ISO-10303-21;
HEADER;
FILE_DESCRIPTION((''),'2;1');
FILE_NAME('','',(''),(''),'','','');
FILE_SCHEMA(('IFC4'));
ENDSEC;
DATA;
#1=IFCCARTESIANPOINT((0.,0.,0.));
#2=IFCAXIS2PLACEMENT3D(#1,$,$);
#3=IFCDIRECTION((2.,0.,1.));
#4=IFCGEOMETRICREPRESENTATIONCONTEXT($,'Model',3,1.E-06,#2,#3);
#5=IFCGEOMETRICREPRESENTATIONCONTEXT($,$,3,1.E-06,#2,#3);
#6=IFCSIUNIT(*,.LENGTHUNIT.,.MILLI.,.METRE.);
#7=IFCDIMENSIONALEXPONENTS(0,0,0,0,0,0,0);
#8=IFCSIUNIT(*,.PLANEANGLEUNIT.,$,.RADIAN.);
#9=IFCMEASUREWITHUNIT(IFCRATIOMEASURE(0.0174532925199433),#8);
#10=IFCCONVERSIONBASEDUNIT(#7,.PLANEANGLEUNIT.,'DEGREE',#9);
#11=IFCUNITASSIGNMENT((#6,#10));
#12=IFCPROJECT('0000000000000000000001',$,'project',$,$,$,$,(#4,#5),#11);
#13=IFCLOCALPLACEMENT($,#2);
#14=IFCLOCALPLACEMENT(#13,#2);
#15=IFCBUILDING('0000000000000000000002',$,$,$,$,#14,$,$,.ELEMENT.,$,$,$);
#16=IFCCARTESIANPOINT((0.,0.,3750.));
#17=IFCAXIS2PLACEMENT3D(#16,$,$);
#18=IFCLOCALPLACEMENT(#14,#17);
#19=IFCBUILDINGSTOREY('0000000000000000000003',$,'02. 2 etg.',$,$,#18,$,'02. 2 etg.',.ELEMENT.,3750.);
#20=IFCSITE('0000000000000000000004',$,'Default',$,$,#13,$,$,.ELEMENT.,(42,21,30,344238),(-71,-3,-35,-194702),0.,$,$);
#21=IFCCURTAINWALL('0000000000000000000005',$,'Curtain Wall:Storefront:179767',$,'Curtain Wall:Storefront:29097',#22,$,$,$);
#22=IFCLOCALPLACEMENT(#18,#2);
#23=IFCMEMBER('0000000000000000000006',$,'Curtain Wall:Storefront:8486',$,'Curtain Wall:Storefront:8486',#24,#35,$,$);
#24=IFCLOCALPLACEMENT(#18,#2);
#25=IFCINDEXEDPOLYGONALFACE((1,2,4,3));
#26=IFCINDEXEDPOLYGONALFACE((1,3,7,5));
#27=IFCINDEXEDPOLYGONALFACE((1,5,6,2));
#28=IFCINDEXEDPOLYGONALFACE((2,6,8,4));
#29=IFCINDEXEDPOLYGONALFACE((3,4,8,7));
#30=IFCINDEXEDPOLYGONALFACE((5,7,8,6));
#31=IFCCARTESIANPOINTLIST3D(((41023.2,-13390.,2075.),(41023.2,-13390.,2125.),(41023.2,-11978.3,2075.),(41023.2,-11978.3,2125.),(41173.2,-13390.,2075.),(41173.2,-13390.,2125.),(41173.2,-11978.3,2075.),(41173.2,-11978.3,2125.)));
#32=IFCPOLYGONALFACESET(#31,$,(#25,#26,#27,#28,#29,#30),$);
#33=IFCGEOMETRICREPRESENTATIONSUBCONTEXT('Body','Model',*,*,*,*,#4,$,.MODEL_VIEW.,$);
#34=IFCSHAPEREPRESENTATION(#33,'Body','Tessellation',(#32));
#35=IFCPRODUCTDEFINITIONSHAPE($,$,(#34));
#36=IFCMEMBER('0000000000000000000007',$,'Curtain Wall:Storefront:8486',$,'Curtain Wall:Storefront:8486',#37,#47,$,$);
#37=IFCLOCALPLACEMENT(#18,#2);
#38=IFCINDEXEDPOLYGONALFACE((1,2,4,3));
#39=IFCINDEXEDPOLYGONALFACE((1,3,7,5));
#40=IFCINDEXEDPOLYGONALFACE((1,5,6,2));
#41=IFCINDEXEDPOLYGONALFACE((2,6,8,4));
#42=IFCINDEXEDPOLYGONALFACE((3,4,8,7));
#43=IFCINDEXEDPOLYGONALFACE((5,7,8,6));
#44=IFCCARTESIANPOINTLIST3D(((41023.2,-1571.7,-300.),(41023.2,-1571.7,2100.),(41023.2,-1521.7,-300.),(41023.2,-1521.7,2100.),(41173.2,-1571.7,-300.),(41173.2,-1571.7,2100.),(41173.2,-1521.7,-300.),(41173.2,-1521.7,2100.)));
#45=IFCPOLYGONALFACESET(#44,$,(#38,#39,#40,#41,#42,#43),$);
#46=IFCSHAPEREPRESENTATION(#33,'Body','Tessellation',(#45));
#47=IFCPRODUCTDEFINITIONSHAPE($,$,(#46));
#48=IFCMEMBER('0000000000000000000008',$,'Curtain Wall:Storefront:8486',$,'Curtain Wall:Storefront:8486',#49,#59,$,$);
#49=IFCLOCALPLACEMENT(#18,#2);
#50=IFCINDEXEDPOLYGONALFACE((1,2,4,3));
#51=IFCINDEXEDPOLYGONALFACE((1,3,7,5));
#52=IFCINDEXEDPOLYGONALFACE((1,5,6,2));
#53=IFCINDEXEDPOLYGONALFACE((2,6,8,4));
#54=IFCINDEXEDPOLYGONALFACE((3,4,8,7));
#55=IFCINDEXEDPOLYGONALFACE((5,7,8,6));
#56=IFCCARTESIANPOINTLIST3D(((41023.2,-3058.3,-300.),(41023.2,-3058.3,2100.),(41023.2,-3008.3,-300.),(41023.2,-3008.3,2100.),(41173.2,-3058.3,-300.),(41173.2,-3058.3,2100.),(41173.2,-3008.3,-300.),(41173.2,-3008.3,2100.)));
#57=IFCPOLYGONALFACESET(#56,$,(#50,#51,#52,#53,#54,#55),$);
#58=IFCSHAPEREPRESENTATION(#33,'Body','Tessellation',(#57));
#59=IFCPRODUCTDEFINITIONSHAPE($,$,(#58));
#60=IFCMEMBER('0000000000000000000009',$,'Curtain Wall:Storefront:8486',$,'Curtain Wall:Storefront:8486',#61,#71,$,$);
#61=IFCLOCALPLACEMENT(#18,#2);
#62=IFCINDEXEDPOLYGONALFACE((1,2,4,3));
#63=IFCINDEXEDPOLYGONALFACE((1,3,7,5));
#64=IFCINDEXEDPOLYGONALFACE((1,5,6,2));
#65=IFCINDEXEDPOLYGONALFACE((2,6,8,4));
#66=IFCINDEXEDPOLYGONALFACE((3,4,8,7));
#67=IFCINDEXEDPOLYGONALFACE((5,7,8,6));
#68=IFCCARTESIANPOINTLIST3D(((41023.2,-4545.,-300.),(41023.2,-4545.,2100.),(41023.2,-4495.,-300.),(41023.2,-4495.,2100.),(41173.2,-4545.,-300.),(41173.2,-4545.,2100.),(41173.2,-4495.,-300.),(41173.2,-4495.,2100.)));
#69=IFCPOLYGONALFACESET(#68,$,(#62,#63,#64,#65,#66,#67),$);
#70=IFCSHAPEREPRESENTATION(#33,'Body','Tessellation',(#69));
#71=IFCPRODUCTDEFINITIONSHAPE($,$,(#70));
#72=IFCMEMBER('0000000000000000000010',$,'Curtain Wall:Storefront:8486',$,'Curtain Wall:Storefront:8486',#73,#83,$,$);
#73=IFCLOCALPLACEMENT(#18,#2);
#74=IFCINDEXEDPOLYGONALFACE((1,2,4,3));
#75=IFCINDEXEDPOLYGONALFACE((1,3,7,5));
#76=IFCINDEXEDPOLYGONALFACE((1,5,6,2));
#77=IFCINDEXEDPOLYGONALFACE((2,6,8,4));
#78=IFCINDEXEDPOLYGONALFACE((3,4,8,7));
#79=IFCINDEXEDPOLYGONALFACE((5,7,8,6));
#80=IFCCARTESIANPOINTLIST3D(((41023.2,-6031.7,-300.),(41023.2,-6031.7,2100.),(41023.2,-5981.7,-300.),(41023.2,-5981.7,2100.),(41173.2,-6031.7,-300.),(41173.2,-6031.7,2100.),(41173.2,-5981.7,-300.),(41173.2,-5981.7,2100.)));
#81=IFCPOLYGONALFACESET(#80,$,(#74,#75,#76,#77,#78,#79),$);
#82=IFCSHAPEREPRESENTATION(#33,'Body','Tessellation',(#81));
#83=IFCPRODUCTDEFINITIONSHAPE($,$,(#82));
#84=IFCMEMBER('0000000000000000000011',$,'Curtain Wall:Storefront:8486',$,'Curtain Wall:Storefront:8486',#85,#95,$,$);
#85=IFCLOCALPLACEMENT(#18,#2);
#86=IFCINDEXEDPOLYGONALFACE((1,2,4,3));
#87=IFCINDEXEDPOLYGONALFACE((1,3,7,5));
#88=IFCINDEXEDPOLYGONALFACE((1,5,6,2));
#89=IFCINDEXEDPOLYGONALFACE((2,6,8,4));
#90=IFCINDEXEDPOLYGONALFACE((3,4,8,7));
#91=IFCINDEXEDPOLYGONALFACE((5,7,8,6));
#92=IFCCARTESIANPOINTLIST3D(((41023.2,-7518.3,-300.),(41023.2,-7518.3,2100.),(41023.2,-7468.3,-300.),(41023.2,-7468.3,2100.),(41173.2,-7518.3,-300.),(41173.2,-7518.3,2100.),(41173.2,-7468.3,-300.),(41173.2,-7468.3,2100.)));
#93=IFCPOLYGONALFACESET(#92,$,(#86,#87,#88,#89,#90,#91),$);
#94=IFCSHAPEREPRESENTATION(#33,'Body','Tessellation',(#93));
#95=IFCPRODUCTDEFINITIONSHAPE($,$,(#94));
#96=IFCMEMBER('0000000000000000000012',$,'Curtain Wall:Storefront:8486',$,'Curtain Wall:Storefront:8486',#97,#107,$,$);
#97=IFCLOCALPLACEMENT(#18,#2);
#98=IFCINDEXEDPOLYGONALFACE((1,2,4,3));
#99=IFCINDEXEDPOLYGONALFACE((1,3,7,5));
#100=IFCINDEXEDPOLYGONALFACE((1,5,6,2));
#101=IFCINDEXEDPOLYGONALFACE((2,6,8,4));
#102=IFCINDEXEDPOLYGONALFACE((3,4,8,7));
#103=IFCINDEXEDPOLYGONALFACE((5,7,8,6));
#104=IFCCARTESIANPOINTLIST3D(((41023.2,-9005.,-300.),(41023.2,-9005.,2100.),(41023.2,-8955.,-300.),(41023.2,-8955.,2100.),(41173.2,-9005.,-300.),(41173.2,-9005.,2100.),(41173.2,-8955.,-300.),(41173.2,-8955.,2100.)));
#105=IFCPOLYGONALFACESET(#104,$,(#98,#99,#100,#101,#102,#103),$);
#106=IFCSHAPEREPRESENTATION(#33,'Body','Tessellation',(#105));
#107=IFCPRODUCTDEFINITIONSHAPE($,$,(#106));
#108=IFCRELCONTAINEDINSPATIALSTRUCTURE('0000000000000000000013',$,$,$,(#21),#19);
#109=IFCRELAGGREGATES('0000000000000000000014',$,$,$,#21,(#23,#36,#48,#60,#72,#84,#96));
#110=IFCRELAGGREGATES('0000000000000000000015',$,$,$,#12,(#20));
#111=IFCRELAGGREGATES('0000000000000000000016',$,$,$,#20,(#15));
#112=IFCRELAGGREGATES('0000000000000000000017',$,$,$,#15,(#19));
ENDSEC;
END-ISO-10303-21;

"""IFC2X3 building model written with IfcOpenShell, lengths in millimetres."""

from ifc_helpers import new_model, entity, si_unit, converted_unit, direction, frame, frame_2d, origin, place, context, subcontext, project, spatial, rectangle, extrude, element, aggregate, save


model = new_model("IFC2X3")

# Units and contexts
model_context = context("Model", 3, precision=1e-06, world=origin(), true_north=direction((2.0, 0.0, 1.0)))
context_of_model = context(None, 3, precision=1e-06, world=origin(), true_north=direction((2.0, 0.0, 1.0)))
body_context = subcontext(model_context, "Body", "Model", "MODEL_VIEW")
ifc_project = project(units=[si_unit("LENGTHUNIT", "METRE", prefix="MILLI"), converted_unit("PLANEANGLEUNIT", "DEGREE", entity("IfcRatioMeasure", 0.0174532925199433), si_unit("PLANEANGLEUNIT", "RADIAN"), dimensions=[0, 0, 0, 0, 0, 0, 0])], contexts=[model_context, context_of_model])

# Site, building, storey
site_placement = place(None, origin())
site = spatial("IfcSite", under=ifc_project, at=site_placement, Name="Default", CompositionType="ELEMENT", RefLatitude=(42, 21, 30, 344238), RefLongitude=(-71, -3, -35, -194702), RefElevation=0.0)
building_placement = place(site_placement, origin())
building = spatial("IfcBuilding", under=site, at=building_placement, CompositionType="ELEMENT")
storey_placement = place(building_placement, frame((0.0, 0.0, 3750.0)))
storey = spatial("IfcBuildingStorey", under=building, at=storey_placement, Name="02. 2 etg.", LongName="02. 2 etg.", CompositionType="ELEMENT", Elevation=3750.0)

# Curtain wall, members
curtain_wall_placement = place(storey_placement, origin())
curtain_wall = element("IfcCurtainWall", 1, at=curtain_wall_placement, inside=storey, Name="Curtain Wall:Storefront:179767", ObjectType="Curtain Wall:Storefront:29097")
member_1_placement = place(storey_placement, origin())
member_1 = element("IfcMember", 2, at=member_1_placement, Name="Curtain Wall:Storefront:8486", ObjectType="Curtain Wall:Storefront:8486", context=body_context, shape_type="SweptSolid", body=[
    extrude(rectangle(XDim=1411.7, YDim=150.0, at=frame_2d((0.0, 0.0), x_axis=(1.0, 0.0))), frame((41098.2, -12684.2, 2075.0), z_axis=(0.0, 0.0, 1.0), x_axis=(0.0, 1.0, 0.0)), (0.0, 0.0, 1.0), 50.0),
])
member_2_placement = place(storey_placement, origin())
member_2 = element("IfcMember", 3, at=member_2_placement, Name="Curtain Wall:Storefront:8486", ObjectType="Curtain Wall:Storefront:8486", context=body_context, shape_type="SweptSolid", body=[
    extrude(rectangle(XDim=150.0, YDim=50.0, at=frame_2d((0.0, 0.0), x_axis=(1.0, 0.0))), frame((41098.2, -1546.7, -300.0)), (0.0, 0.0, 1.0), 2400.0),
])
member_3_placement = place(storey_placement, origin())
member_3 = element("IfcMember", 4, at=member_3_placement, Name="Curtain Wall:Storefront:8486", ObjectType="Curtain Wall:Storefront:8486", context=body_context, shape_type="SweptSolid", body=[
    extrude(rectangle(XDim=150.0, YDim=50.0, at=frame_2d((0.0, 0.0), x_axis=(1.0, 0.0))), frame((41098.2, -3033.3, -300.0)), (0.0, 0.0, 1.0), 2400.0),
])
member_4_placement = place(storey_placement, origin())
member_4 = element("IfcMember", 5, at=member_4_placement, Name="Curtain Wall:Storefront:8486", ObjectType="Curtain Wall:Storefront:8486", context=body_context, shape_type="SweptSolid", body=[
    extrude(rectangle(XDim=150.0, YDim=50.0, at=frame_2d((0.0, 0.0), x_axis=(1.0, 0.0))), frame((41098.2, -4520.0, -300.0)), (0.0, 0.0, 1.0), 2400.0),
])
member_5_placement = place(storey_placement, origin())
member_5 = element("IfcMember", 6, at=member_5_placement, Name="Curtain Wall:Storefront:8486", ObjectType="Curtain Wall:Storefront:8486", context=body_context, shape_type="SweptSolid", body=[
    extrude(rectangle(XDim=150.0, YDim=50.0, at=frame_2d((0.0, 0.0), x_axis=(1.0, 0.0))), frame((41098.2, -6006.7, -300.0)), (0.0, 0.0, 1.0), 2400.0),
])
member_6_placement = place(storey_placement, origin())
member_6 = element("IfcMember", 7, at=member_6_placement, Name="Curtain Wall:Storefront:8486", ObjectType="Curtain Wall:Storefront:8486", context=body_context, shape_type="SweptSolid", body=[
    extrude(rectangle(XDim=150.0, YDim=50.0, at=frame_2d((0.0, 0.0), x_axis=(1.0, 0.0))), frame((41098.2, -7493.3, -300.0)), (0.0, 0.0, 1.0), 2400.0),
])
member_7_placement = place(storey_placement, origin())
member_7 = element("IfcMember", 8, at=member_7_placement, Name="Curtain Wall:Storefront:8486", ObjectType="Curtain Wall:Storefront:8486", context=body_context, shape_type="SweptSolid", body=[
    extrude(rectangle(XDim=150.0, YDim=50.0, at=frame_2d((0.0, 0.0), x_axis=(1.0, 0.0))), frame((41098.2, -8980.0, -300.0)), (0.0, 0.0, 1.0), 2400.0),
])
aggregate(curtain_wall, [member_1, member_2, member_3, member_4, member_5, member_6, member_7])

save(model, "model.ifc")
